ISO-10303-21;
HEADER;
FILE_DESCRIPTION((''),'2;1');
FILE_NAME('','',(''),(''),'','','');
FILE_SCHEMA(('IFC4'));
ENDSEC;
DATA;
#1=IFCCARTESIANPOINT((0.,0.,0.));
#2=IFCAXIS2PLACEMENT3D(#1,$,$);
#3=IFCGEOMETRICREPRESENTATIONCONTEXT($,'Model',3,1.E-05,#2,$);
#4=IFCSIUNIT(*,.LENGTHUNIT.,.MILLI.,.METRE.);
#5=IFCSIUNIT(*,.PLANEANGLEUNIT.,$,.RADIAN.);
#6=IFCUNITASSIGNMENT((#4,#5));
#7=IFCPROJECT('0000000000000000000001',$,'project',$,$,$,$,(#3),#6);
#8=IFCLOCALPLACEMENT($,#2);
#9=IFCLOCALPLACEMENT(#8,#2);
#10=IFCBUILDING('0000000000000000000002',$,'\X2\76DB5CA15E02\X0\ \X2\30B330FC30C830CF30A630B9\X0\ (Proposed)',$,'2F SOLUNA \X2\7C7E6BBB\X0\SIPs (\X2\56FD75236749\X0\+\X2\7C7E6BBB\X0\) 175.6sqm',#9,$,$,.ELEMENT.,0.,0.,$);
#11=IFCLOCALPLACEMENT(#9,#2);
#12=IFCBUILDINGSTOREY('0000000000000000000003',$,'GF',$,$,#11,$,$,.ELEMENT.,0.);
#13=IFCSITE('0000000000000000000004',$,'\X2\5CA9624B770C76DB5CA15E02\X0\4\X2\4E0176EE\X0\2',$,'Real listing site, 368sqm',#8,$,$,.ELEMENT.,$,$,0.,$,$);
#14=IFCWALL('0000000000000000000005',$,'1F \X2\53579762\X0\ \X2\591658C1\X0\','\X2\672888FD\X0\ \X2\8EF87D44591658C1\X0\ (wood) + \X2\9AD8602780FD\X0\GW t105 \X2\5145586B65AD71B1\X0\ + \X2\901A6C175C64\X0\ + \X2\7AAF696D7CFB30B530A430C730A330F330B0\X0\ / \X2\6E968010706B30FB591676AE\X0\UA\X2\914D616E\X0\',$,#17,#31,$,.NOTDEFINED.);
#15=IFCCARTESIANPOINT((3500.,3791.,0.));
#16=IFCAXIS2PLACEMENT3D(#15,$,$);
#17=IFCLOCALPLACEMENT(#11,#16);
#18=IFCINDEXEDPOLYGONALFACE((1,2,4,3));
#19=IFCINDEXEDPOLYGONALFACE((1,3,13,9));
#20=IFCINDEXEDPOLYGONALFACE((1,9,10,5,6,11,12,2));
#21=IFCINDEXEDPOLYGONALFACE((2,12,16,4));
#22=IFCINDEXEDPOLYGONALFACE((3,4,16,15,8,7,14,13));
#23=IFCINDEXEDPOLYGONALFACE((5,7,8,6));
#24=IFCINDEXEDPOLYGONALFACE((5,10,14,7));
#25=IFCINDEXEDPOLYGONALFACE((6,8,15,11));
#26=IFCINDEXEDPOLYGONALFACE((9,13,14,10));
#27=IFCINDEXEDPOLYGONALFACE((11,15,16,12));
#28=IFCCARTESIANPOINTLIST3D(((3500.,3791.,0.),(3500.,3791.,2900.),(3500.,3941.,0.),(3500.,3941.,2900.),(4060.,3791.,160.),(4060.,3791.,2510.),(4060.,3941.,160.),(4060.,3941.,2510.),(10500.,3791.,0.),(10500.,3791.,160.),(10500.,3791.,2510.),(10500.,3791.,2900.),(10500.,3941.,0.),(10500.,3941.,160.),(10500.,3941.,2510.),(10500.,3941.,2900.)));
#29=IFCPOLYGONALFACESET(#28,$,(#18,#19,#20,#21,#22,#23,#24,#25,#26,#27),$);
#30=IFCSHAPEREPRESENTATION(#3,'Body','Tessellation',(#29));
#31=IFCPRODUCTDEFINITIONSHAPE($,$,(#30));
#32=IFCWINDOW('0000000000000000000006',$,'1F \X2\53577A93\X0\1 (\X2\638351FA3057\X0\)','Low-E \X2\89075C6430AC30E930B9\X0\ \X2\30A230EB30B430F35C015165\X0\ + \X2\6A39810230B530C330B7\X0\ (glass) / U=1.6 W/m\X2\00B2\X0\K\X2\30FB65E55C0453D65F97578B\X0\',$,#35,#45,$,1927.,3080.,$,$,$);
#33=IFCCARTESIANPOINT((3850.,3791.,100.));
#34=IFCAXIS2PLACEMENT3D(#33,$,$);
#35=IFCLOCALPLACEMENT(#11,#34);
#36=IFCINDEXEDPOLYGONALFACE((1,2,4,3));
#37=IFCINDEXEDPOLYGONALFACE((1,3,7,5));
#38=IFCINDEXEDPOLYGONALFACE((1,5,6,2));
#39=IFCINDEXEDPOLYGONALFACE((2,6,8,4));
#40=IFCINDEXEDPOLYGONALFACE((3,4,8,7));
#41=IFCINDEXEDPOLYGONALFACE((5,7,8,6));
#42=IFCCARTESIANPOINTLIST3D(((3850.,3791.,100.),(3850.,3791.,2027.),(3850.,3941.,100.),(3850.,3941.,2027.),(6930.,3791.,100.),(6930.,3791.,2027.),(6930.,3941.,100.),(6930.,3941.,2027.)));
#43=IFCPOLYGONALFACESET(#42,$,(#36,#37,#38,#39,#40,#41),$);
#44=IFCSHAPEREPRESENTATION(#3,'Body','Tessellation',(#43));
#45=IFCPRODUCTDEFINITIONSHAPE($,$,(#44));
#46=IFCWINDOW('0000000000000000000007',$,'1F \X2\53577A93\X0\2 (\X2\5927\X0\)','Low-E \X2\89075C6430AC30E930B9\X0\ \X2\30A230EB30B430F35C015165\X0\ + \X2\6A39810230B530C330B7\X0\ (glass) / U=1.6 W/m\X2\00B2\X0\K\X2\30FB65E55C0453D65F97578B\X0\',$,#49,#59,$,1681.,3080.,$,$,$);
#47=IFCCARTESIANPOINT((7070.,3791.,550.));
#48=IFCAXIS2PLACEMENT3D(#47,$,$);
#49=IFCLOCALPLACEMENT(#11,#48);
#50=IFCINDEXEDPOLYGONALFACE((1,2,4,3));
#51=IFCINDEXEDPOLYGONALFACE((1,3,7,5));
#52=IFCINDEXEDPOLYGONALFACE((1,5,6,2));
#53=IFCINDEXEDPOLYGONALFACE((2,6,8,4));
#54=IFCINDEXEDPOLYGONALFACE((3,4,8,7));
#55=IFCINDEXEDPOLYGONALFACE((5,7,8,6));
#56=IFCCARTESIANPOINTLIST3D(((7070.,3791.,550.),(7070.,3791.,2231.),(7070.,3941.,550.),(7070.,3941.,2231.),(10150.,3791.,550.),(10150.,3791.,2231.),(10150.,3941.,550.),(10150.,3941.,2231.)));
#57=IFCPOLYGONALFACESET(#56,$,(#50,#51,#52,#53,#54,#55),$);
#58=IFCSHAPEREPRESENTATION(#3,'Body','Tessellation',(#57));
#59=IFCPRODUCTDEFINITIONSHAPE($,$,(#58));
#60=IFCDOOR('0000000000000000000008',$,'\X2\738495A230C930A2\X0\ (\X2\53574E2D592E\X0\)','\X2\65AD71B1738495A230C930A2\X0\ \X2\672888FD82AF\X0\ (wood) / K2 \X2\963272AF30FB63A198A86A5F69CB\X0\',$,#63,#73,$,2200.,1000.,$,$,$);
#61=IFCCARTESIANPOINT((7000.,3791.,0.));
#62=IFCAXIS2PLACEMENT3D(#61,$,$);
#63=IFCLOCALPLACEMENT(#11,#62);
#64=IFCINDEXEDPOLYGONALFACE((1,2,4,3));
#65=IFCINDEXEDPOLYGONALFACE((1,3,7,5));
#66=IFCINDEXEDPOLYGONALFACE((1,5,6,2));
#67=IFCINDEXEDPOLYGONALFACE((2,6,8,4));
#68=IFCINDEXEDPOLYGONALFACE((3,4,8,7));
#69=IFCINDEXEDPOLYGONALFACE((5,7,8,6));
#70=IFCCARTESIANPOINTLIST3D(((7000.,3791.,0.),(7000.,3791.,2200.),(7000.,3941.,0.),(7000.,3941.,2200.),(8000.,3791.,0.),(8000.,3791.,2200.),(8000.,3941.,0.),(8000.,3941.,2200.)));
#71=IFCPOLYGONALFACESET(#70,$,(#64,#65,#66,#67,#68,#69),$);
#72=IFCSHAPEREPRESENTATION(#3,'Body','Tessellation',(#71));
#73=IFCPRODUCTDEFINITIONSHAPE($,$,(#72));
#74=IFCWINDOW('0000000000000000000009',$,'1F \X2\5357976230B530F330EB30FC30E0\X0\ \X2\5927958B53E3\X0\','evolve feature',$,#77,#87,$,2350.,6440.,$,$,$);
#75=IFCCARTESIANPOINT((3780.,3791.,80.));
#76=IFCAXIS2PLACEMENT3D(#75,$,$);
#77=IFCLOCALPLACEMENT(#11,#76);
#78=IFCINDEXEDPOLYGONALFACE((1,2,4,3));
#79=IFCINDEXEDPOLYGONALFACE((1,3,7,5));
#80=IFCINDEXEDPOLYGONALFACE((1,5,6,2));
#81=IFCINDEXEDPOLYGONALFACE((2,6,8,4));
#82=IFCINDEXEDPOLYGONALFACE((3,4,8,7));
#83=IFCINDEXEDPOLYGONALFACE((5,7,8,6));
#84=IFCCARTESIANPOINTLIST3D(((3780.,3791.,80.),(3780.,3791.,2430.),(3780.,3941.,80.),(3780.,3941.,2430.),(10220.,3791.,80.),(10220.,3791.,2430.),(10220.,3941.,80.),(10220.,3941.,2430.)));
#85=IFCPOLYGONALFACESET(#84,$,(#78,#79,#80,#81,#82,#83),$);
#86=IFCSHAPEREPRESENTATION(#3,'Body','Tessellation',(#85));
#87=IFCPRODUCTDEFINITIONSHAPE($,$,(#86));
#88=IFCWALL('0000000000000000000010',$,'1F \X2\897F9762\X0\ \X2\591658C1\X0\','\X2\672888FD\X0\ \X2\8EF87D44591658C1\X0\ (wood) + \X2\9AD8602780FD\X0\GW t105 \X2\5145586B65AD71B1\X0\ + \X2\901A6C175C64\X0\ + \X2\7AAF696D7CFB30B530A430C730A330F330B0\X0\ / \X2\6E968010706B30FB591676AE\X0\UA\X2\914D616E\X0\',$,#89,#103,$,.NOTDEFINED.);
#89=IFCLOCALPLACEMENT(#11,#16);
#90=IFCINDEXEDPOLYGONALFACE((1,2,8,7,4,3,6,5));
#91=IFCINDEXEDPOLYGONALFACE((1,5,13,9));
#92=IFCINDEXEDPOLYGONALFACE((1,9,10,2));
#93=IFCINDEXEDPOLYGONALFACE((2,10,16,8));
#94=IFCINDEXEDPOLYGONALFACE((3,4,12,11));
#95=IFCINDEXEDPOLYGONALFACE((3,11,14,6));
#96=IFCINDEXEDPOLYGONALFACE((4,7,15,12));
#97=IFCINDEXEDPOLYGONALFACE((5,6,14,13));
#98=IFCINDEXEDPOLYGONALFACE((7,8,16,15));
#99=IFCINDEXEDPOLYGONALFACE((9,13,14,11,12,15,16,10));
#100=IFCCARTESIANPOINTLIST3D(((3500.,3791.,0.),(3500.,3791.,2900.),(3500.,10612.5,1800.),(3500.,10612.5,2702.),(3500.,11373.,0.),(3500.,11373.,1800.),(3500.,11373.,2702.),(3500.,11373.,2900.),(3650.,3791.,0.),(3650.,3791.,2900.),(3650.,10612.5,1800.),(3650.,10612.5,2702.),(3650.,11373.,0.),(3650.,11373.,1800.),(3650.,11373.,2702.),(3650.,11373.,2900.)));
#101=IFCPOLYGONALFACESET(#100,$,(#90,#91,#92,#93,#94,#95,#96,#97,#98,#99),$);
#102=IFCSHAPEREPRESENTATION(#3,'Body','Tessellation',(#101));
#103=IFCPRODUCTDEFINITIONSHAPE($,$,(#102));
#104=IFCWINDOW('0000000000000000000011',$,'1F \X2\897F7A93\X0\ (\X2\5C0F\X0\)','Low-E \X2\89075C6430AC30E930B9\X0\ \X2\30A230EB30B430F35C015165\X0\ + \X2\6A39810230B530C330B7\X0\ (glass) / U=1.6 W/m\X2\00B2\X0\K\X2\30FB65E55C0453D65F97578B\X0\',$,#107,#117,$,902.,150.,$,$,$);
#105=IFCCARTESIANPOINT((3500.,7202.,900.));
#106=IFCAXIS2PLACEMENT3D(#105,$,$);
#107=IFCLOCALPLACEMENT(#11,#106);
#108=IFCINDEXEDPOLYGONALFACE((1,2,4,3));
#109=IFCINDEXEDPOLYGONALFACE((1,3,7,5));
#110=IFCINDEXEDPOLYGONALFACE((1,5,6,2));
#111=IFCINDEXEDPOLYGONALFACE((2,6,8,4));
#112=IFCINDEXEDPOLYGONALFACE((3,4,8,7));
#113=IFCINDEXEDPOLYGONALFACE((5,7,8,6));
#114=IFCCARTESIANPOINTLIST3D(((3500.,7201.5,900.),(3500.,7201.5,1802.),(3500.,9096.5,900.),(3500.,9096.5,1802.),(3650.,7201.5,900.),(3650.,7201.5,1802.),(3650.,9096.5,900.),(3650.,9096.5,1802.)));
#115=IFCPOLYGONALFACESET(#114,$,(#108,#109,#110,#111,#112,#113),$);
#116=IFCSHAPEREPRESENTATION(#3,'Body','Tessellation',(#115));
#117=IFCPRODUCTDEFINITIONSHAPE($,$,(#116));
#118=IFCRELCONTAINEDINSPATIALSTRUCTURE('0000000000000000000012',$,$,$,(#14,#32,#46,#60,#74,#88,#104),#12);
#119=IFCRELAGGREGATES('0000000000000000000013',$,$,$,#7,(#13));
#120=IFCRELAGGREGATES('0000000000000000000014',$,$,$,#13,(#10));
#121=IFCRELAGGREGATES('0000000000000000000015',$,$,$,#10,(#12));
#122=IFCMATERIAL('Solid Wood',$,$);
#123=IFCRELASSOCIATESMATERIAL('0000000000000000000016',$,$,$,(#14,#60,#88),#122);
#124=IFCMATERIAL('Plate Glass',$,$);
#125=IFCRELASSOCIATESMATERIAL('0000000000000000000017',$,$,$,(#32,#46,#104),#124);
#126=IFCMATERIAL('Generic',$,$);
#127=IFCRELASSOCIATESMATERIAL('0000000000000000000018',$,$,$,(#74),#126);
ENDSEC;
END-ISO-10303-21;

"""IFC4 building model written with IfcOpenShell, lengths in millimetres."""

from ifc_helpers import new_model, si_unit, frame, frame_2d, origin, place, context, project, spatial, rectangle, extrude, material, element, fill, save


model = new_model("IFC4")

# Units and contexts
model_context = context("Model", 3, precision=1e-05, world=origin())
ifc_project = project(units=[si_unit("LENGTHUNIT", "METRE", prefix="MILLI"), si_unit("PLANEANGLEUNIT", "RADIAN")], contexts=[model_context])

# Site, building, storey
site_placement = place(None, origin())
site = spatial("IfcSite", under=ifc_project, at=site_placement, Name="岩手県盛岡市4丁目2", ObjectType="Real listing site, 368sqm", CompositionType="ELEMENT", RefElevation=0.0)
building_placement = place(site_placement, origin())
building = spatial("IfcBuilding", under=site, at=building_placement, Name="盛岡市 コートハウス (Proposed)", ObjectType="2F SOLUNA 籾殻SIPs (国産杉+籾殻) 175.6sqm", CompositionType="ELEMENT", ElevationOfRefHeight=0.0, ElevationOfTerrain=0.0)
storey_placement = place(building_placement, origin())
storey = spatial("IfcBuildingStorey", under=building, at=storey_placement, Name="GF", CompositionType="ELEMENT", Elevation=0.0)

# Shared definitions
ifc_material_1 = material(Name="Solid Wood")
ifc_material_2 = material(Name="Generic")

# Wall, openings, windows, door
wall_1_placement = place(storey_placement, frame((3500.0, 3791.0, 0.0)))
wall_1 = element("IfcWall", 1, at=wall_1_placement, inside=storey, material=ifc_material_1, Name="1F 南面 外壁", Description="木製 軸組外壁 (wood) + 高性能GW t105 充填断熱 + 通気層 + 窯業系サイディング / 準耐火・外皮UA配慮", PredefinedType="NOTDEFINED", context=model_context, shape_type="SweptSolid", body=[
    extrude(rectangle(XDim=7000.0, YDim=150.0, at=frame_2d((3500.0, 75.0))), frame((3500.0, 3791.0, 0.0)), (0.0, 0.0, 1.0), 2900.0),
])
opening_1_placement = place(storey_placement, frame((3850.0, 3791.0, 100.0)))
opening_1 = element("IfcOpeningElement", 2, at=opening_1_placement, cuts=wall_1, PredefinedType="NOTDEFINED", context=model_context, shape_type="SweptSolid", body=[
    extrude(rectangle(XDim=3080.0, YDim=150.0, at=frame_2d((1540.0, 75.0))), frame((3850.0, 3791.0, 100.0)), (0.0, 0.0, 1.0), 1927.0),
])
opening_2_placement = place(storey_placement, frame((7070.0, 3791.0, 550.0)))
opening_2 = element("IfcOpeningElement", 3, at=opening_2_placement, cuts=wall_1, PredefinedType="NOTDEFINED", context=model_context, shape_type="SweptSolid", body=[
    extrude(rectangle(XDim=3080.0, YDim=150.0, at=frame_2d((1540.0, 75.0))), frame((7070.0, 3791.0, 550.0)), (0.0, 0.0, 1.0), 1681.0),
])
opening_3_placement = place(storey_placement, frame((7000.0, 3791.0, 0.0)))
opening_3 = element("IfcOpeningElement", 4, at=opening_3_placement, cuts=wall_1, PredefinedType="NOTDEFINED", context=model_context, shape_type="SweptSolid", body=[
    extrude(rectangle(XDim=1000.0, YDim=150.0, at=frame_2d((500.0, 75.0))), frame((7000.0, 3791.0, 0.0)), (0.0, 0.0, 1.0), 2200.0),
])
opening_4_placement = place(storey_placement, frame((3780.0, 3791.0, 80.0)))
opening_4 = element("IfcOpeningElement", 5, at=opening_4_placement, cuts=wall_1, PredefinedType="NOTDEFINED", context=model_context, shape_type="SweptSolid", body=[
    extrude(rectangle(XDim=6440.0, YDim=150.0, at=frame_2d((3220.0, 75.0))), frame((3780.0, 3791.0, 80.0)), (0.0, 0.0, 1.0), 2350.0),
])
ifc_material_3 = material(Name="Plate Glass")
window_1_placement = place(storey_placement, frame((3850.0, 3791.0, 100.0)))
window_1 = element("IfcWindow", 6, at=window_1_placement, inside=storey, material=ifc_material_3, Name="1F 南窓1 (掃出し)", Description="Low-E 複層ガラス アルゴン封入 + 樹脂サッシ (glass) / U=1.6 W/m²K・日射取得型", OverallHeight=1927.0, OverallWidth=3080.0, context=model_context, shape_type="SweptSolid", body=[
    extrude(rectangle(XDim=3080.0, YDim=150.0, at=frame_2d((1540.0, 75.0))), frame((3850.0, 3791.0, 100.0)), (0.0, 0.0, 1.0), 1927.0),
])
fill(opening_1, window_1)
window_2_placement = place(storey_placement, frame((7070.0, 3791.0, 550.0)))
window_2 = element("IfcWindow", 7, at=window_2_placement, inside=storey, material=ifc_material_3, Name="1F 南窓2 (大)", Description="Low-E 複層ガラス アルゴン封入 + 樹脂サッシ (glass) / U=1.6 W/m²K・日射取得型", OverallHeight=1681.0, OverallWidth=3080.0, context=model_context, shape_type="SweptSolid", body=[
    extrude(rectangle(XDim=3080.0, YDim=150.0, at=frame_2d((1540.0, 75.0))), frame((7070.0, 3791.0, 550.0)), (0.0, 0.0, 1.0), 1681.0),
])
fill(opening_2, window_2)
door_placement = place(storey_placement, frame((7000.0, 3791.0, 0.0)))
door = element("IfcDoor", 8, at=door_placement, inside=storey, material=ifc_material_1, Name="玄関ドア (南中央)", Description="断熱玄関ドア 木製芯 (wood) / K2 防犯・採風機構", OverallHeight=2200.0, OverallWidth=1000.0, context=model_context, shape_type="SweptSolid", body=[
    extrude(rectangle(XDim=1000.0, YDim=150.0, at=frame_2d((500.0, 75.0))), frame((7000.0, 3791.0, 0.0)), (0.0, 0.0, 1.0), 2200.0),
])
fill(opening_3, door)
window_3_placement = place(storey_placement, frame((3780.0, 3791.0, 80.0)))
window_3 = element("IfcWindow", 9, at=window_3_placement, inside=storey, material=ifc_material_2, Name="1F 南面サンルーム 大開口", Description="evolve feature", OverallHeight=2350.0, OverallWidth=6440.0, context=model_context, shape_type="SweptSolid", body=[
    extrude(rectangle(XDim=6440.0, YDim=150.0, at=frame_2d((3220.0, 75.0))), frame((3780.0, 3791.0, 80.0)), (0.0, 0.0, 1.0), 2350.0),
])
fill(opening_4, window_3)

# Wall, opening, window
wall_2_placement = place(storey_placement, frame((3500.0, 3791.0, 0.0)))
wall_2 = element("IfcWall", 10, at=wall_2_placement, inside=storey, material=ifc_material_1, Name="1F 西面 外壁", Description="木製 軸組外壁 (wood) + 高性能GW t105 充填断熱 + 通気層 + 窯業系サイディング / 準耐火・外皮UA配慮", PredefinedType="NOTDEFINED", context=model_context, shape_type="SweptSolid", body=[
    extrude(rectangle(XDim=150.0, YDim=7582.0, at=frame_2d((75.0, 3791.0))), frame((3500.0, 3791.0, 0.0)), (0.0, 0.0, 1.0), 2900.0),
])
opening_5_placement = place(storey_placement, frame((3500.0, 7202.0, 900.0)))
opening_5 = element("IfcOpeningElement", 11, at=opening_5_placement, cuts=wall_2, PredefinedType="NOTDEFINED", context=model_context, shape_type="SweptSolid", body=[
    extrude(rectangle(XDim=150.0, YDim=1895.0, at=frame_2d((75.0, 947.0))), frame((3500.0, 7202.0, 900.0)), (0.0, 0.0, 1.0), 902.0),
])
window_4_placement = place(storey_placement, frame((3500.0, 7202.0, 900.0)))
window_4 = element("IfcWindow", 12, at=window_4_placement, inside=storey, material=ifc_material_3, Name="1F 西窓 (小)", Description="Low-E 複層ガラス アルゴン封入 + 樹脂サッシ (glass) / U=1.6 W/m²K・日射取得型", OverallHeight=902.0, OverallWidth=150.0, context=model_context, shape_type="SweptSolid", body=[
    extrude(rectangle(XDim=150.0, YDim=1895.0, at=frame_2d((75.0, 947.0))), frame((3500.0, 7202.0, 900.0)), (0.0, 0.0, 1.0), 902.0),
])
fill(opening_5, window_4)

save(model, "model.ifc")
